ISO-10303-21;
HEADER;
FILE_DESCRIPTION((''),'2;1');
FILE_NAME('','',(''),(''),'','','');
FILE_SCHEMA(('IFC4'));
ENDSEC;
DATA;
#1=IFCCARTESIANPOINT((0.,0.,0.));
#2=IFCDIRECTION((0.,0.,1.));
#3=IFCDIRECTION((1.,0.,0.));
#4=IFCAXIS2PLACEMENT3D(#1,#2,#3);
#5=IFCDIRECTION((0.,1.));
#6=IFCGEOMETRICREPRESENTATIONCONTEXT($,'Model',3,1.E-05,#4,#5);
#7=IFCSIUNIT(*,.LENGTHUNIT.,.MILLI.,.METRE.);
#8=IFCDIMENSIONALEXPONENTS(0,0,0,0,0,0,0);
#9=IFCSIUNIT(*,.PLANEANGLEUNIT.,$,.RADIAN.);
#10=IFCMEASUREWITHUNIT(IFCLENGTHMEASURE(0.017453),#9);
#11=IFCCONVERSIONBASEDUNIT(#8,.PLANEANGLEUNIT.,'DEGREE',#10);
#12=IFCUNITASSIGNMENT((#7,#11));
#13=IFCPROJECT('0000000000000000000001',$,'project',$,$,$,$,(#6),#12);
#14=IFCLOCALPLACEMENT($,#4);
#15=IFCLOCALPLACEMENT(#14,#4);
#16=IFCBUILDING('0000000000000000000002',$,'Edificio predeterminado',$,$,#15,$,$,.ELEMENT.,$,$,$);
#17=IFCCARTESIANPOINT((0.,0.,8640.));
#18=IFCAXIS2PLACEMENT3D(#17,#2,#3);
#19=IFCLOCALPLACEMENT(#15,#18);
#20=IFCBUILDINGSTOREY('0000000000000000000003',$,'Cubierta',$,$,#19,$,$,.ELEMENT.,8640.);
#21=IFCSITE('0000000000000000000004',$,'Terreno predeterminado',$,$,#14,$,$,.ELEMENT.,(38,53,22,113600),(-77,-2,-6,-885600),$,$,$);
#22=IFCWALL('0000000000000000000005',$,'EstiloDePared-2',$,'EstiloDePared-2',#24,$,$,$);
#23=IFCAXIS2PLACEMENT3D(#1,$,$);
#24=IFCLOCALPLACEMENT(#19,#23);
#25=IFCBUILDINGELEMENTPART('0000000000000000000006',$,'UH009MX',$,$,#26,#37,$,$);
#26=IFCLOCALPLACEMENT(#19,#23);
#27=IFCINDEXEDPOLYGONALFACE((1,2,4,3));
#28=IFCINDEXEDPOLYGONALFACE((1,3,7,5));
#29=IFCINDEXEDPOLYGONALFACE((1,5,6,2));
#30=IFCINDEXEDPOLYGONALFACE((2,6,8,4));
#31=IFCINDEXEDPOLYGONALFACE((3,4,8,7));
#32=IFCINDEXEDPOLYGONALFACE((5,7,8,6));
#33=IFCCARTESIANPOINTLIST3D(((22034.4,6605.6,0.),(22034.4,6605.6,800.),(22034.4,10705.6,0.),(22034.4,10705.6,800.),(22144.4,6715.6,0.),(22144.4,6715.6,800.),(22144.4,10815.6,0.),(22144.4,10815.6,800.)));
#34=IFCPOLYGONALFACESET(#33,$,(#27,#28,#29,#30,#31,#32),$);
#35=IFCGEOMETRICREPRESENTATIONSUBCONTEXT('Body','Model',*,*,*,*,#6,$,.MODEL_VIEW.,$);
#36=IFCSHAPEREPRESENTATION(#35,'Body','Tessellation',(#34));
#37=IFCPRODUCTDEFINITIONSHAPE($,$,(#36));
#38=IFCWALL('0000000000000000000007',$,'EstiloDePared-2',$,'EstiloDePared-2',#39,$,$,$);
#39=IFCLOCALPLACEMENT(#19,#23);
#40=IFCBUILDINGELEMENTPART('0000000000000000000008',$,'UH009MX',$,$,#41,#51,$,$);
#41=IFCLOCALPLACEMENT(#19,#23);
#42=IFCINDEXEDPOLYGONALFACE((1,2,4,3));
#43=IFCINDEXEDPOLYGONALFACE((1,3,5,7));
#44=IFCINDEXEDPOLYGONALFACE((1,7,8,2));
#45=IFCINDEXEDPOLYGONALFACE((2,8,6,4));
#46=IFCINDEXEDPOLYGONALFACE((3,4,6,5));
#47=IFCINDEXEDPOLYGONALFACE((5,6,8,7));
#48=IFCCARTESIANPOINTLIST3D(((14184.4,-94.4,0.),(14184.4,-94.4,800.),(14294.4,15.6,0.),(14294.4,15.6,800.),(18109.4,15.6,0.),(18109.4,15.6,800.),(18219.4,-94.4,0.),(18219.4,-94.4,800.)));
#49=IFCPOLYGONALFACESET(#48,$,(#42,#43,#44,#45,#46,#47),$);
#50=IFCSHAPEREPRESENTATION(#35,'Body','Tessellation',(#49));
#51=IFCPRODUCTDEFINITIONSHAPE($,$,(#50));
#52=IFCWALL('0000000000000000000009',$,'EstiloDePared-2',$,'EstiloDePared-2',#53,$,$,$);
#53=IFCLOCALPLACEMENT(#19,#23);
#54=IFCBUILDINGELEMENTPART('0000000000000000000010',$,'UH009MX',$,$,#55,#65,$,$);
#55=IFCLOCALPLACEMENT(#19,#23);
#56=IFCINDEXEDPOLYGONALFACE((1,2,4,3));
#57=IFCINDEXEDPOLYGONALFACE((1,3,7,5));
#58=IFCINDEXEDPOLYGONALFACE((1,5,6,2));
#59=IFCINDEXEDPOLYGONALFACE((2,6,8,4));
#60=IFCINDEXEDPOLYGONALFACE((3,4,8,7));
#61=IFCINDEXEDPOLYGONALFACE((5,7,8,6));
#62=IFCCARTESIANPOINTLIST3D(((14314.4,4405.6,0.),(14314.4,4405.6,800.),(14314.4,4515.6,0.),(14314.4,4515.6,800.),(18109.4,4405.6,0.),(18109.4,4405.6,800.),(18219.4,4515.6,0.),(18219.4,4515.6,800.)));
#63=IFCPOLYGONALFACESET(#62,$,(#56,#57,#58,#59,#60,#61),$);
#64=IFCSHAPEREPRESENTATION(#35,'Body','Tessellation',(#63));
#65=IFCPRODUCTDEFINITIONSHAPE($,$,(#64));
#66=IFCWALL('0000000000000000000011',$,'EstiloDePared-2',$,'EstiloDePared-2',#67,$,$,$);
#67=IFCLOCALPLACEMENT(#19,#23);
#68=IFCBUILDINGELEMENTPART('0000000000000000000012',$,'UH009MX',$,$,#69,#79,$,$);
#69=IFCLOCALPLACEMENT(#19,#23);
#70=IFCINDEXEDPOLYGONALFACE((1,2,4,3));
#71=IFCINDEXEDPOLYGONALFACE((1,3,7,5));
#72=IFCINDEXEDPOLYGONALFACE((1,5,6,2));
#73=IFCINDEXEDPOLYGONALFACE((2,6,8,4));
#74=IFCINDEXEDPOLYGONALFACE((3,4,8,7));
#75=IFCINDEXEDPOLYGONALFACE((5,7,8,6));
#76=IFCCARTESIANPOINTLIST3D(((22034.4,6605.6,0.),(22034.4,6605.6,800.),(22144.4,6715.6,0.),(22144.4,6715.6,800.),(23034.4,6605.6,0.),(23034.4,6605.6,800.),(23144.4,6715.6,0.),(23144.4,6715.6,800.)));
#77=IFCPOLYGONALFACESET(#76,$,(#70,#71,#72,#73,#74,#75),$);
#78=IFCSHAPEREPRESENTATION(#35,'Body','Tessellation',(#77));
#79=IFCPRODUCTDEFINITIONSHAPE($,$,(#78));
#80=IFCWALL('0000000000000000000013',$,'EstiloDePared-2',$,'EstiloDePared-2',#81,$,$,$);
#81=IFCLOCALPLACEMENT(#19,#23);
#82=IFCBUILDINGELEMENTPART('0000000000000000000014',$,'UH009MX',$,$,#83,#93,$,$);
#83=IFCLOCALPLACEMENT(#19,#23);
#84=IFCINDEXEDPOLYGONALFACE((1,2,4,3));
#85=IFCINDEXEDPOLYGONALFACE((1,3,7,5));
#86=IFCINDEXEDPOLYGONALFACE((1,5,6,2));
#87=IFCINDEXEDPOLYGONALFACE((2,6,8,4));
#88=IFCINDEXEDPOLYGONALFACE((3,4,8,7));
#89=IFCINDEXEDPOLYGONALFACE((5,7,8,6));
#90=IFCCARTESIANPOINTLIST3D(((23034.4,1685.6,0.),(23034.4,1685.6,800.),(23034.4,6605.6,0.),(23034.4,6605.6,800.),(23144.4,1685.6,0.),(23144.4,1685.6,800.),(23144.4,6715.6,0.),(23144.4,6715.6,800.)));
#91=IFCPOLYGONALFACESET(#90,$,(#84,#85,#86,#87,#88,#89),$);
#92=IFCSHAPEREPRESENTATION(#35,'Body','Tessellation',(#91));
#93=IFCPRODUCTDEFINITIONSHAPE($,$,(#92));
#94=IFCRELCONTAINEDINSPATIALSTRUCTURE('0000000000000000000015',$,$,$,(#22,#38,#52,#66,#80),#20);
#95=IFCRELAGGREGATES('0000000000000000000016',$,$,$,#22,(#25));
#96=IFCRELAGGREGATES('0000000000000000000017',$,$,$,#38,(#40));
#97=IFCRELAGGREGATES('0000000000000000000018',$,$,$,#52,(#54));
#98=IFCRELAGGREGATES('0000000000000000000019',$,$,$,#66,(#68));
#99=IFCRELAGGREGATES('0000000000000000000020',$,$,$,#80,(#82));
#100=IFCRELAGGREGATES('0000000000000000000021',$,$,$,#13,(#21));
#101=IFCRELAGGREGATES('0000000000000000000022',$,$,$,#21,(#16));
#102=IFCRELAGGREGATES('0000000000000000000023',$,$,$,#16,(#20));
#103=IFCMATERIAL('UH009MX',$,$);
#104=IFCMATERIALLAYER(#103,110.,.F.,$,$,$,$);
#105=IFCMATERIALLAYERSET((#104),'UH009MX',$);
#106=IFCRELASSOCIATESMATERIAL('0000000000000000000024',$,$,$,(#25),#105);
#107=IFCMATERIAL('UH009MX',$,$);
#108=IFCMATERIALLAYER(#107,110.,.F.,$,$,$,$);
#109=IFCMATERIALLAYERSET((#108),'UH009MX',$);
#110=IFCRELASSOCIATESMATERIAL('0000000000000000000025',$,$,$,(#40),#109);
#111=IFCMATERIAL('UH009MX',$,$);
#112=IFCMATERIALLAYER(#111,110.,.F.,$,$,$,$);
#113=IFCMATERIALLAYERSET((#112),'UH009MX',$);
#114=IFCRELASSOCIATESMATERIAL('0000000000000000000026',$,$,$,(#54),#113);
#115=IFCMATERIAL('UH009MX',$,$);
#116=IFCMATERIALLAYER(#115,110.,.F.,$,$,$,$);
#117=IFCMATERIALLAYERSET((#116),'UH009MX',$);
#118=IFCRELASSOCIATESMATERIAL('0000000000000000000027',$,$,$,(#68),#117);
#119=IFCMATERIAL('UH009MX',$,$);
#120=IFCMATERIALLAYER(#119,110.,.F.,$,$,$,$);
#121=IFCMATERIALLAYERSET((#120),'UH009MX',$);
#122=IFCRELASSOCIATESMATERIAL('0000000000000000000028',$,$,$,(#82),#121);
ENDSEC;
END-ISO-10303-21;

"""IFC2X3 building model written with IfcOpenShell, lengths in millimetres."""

from ifc_helpers import new_model, entity, si_unit, converted_unit, direction, frame, origin_with_axes, place, context, subcontext, project, spatial, polyline, outline, extrude, material, layer, layer_set, layer_usage, element, aggregate, save


model = new_model("IFC2X3")

# Units and contexts
model_context = context("Model", 3, precision=1e-05, world=origin_with_axes(), true_north=direction((0.0, 1.0)))
body_context = subcontext(model_context, "Body", "Model", "MODEL_VIEW")
ifc_project = project(units=[si_unit("LENGTHUNIT", "METRE", prefix="MILLI"), converted_unit("PLANEANGLEUNIT", "DEGREE", entity("IfcLengthMeasure", 0.017453), si_unit("PLANEANGLEUNIT", "RADIAN"), dimensions=[0, 0, 0, 0, 0, 0, 0])], contexts=[model_context])

# Site, building, storey
site_placement = place(None, origin_with_axes())
site = spatial("IfcSite", under=ifc_project, at=site_placement, Name="Terreno predeterminado", CompositionType="ELEMENT", RefLatitude=(38, 53, 22, 113600), RefLongitude=(-77, -2, -6, -885600))
building_placement = place(site_placement, origin_with_axes())
building = spatial("IfcBuilding", under=site, at=building_placement, Name="Edificio predeterminado", CompositionType="ELEMENT")
storey_placement = place(building_placement, frame((0.0, 0.0, 8640.0), z_axis=(0.0, 0.0, 1.0), x_axis=(1.0, 0.0, 0.0)))
storey = spatial("IfcBuildingStorey", under=building, at=storey_placement, Name="Cubierta", CompositionType="ELEMENT", Elevation=8640.0)

# Wall, building element part
wall_1_placement = place(storey_placement, frame((22089.4, 10760.6, 0.0), z_axis=(0.0, 0.0, 1.0), x_axis=(0.0, -1.0, 0.0)))
wall_1 = element("IfcWall", 1, at=wall_1_placement, inside=storey, Name="EstiloDePared-2", ObjectType="EstiloDePared-2")
ifc_material_1 = material(Name="UH009MX")
ifc_layer_1 = layer(ifc_material_1, 110.0, ventilated=False)
ifc_layer_set_1 = layer_set([ifc_layer_1], Name="UH009MX")
ifc_layer_usage_1 = layer_usage(ifc_layer_set_1, "AXIS2", "NEGATIVE", -55.0)
building_element_part_1_placement = place(wall_1_placement, origin_with_axes())
building_element_part_1 = element("IfcBuildingElementPart", 2, at=building_element_part_1_placement, material=ifc_layer_usage_1, Name="UH009MX", context=body_context, shape_type="SweptSolid", body=[
    extrude(outline(polyline([(4045.0, 55.0), (4155.0, -55.0), (55.0, -55.0), (-55.0, 55.0), (4045.0, 55.0)])), origin_with_axes(), (0.0, 0.0, 1.0), 800.0),
])
aggregate(wall_1, [building_element_part_1])

# Walls, building element parts
wall_2_placement = place(storey_placement, frame((18164.4, -39.4, 0.0), z_axis=(0.0, 0.0, 1.0), x_axis=(-1.0, 0.0, 0.0)))
wall_2 = element("IfcWall", 3, at=wall_2_placement, inside=storey, Name="EstiloDePared-2", ObjectType="EstiloDePared-2")
ifc_material_2 = material(Name="UH009MX")
ifc_layer_2 = layer(ifc_material_2, 110.0, ventilated=False)
ifc_layer_set_2 = layer_set([ifc_layer_2], Name="UH009MX")
ifc_layer_usage_2 = layer_usage(ifc_layer_set_2, "AXIS2", "NEGATIVE", -55.0)
building_element_part_2_placement = place(wall_2_placement, origin_with_axes())
building_element_part_2 = element("IfcBuildingElementPart", 4, at=building_element_part_2_placement, material=ifc_layer_usage_2, Name="UH009MX", context=body_context, shape_type="SweptSolid", body=[
    extrude(outline(polyline([(3980.0, 55.0), (3870.0, -55.0), (55.0, -55.0), (-55.0, 55.0), (3980.0, 55.0)])), origin_with_axes(), (0.0, 0.0, 1.0), 800.0),
])
aggregate(wall_2, [building_element_part_2])
wall_3_placement = place(storey_placement, frame((18164.4, 4460.6, 0.0), z_axis=(0.0, 0.0, 1.0), x_axis=(-1.0, 0.0, 0.0)))
wall_3 = element("IfcWall", 5, at=wall_3_placement, inside=storey, Name="EstiloDePared-2", ObjectType="EstiloDePared-2")
ifc_material_3 = material(Name="UH009MX")
ifc_layer_3 = layer(ifc_material_3, 110.0, ventilated=False)
ifc_layer_set_3 = layer_set([ifc_layer_3], Name="UH009MX")
ifc_layer_usage_3 = layer_usage(ifc_layer_set_3, "AXIS2", "NEGATIVE", -55.0)
building_element_part_3_placement = place(wall_3_placement, origin_with_axes())
building_element_part_3 = element("IfcBuildingElementPart", 6, at=building_element_part_3_placement, material=ifc_layer_usage_3, Name="UH009MX", context=body_context, shape_type="SweptSolid", body=[
    extrude(outline(polyline([(3850.0, 55.0), (3850.0, -55.0), (-55.0, -55.0), (55.0, 55.0), (3850.0, 55.0)])), origin_with_axes(), (0.0, 0.0, 1.0), 800.0),
])
aggregate(wall_3, [building_element_part_3])
wall_4_placement = place(storey_placement, frame((22089.4, 6660.6, 0.0), z_axis=(0.0, 0.0, 1.0), x_axis=(1.0, 0.0, 0.0)))
wall_4 = element("IfcWall", 7, at=wall_4_placement, inside=storey, Name="EstiloDePared-2", ObjectType="EstiloDePared-2")
ifc_material_4 = material(Name="UH009MX")
ifc_layer_4 = layer(ifc_material_4, 110.0, ventilated=False)
ifc_layer_set_4 = layer_set([ifc_layer_4], Name="UH009MX")
ifc_layer_usage_4 = layer_usage(ifc_layer_set_4, "AXIS2", "NEGATIVE", -55.0)
building_element_part_4_placement = place(wall_4_placement, origin_with_axes())
building_element_part_4 = element("IfcBuildingElementPart", 8, at=building_element_part_4_placement, material=ifc_layer_usage_4, Name="UH009MX", context=body_context, shape_type="SweptSolid", body=[
    extrude(outline(polyline([(1055.0, 55.0), (945.0, -55.0), (-55.0, -55.0), (55.0, 55.0), (1055.0, 55.0)])), origin_with_axes(), (0.0, 0.0, 1.0), 800.0),
])
aggregate(wall_4, [building_element_part_4])
wall_5_placement = place(storey_placement, frame((23089.4, 6660.6, 0.0), z_axis=(0.0, 0.0, 1.0), x_axis=(0.0, -1.0, 0.0)))
wall_5 = element("IfcWall", 9, at=wall_5_placement, inside=storey, Name="EstiloDePared-2", ObjectType="EstiloDePared-2")
ifc_material_5 = material(Name="UH009MX")
ifc_layer_5 = layer(ifc_material_5, 110.0, ventilated=False)
ifc_layer_set_5 = layer_set([ifc_layer_5], Name="UH009MX")
ifc_layer_usage_5 = layer_usage(ifc_layer_set_5, "AXIS2", "NEGATIVE", -55.0)
building_element_part_5_placement = place(wall_5_placement, origin_with_axes())
building_element_part_5 = element("IfcBuildingElementPart", 10, at=building_element_part_5_placement, material=ifc_layer_usage_5, Name="UH009MX", context=body_context, shape_type="SweptSolid", body=[
    extrude(outline(polyline([(4975.0, 55.0), (4975.0, -55.0), (55.0, -55.0), (-55.0, 55.0), (4975.0, 55.0)])), origin_with_axes(), (0.0, 0.0, 1.0), 800.0),
])
aggregate(wall_5, [building_element_part_5])

save(model, "model.ifc")
